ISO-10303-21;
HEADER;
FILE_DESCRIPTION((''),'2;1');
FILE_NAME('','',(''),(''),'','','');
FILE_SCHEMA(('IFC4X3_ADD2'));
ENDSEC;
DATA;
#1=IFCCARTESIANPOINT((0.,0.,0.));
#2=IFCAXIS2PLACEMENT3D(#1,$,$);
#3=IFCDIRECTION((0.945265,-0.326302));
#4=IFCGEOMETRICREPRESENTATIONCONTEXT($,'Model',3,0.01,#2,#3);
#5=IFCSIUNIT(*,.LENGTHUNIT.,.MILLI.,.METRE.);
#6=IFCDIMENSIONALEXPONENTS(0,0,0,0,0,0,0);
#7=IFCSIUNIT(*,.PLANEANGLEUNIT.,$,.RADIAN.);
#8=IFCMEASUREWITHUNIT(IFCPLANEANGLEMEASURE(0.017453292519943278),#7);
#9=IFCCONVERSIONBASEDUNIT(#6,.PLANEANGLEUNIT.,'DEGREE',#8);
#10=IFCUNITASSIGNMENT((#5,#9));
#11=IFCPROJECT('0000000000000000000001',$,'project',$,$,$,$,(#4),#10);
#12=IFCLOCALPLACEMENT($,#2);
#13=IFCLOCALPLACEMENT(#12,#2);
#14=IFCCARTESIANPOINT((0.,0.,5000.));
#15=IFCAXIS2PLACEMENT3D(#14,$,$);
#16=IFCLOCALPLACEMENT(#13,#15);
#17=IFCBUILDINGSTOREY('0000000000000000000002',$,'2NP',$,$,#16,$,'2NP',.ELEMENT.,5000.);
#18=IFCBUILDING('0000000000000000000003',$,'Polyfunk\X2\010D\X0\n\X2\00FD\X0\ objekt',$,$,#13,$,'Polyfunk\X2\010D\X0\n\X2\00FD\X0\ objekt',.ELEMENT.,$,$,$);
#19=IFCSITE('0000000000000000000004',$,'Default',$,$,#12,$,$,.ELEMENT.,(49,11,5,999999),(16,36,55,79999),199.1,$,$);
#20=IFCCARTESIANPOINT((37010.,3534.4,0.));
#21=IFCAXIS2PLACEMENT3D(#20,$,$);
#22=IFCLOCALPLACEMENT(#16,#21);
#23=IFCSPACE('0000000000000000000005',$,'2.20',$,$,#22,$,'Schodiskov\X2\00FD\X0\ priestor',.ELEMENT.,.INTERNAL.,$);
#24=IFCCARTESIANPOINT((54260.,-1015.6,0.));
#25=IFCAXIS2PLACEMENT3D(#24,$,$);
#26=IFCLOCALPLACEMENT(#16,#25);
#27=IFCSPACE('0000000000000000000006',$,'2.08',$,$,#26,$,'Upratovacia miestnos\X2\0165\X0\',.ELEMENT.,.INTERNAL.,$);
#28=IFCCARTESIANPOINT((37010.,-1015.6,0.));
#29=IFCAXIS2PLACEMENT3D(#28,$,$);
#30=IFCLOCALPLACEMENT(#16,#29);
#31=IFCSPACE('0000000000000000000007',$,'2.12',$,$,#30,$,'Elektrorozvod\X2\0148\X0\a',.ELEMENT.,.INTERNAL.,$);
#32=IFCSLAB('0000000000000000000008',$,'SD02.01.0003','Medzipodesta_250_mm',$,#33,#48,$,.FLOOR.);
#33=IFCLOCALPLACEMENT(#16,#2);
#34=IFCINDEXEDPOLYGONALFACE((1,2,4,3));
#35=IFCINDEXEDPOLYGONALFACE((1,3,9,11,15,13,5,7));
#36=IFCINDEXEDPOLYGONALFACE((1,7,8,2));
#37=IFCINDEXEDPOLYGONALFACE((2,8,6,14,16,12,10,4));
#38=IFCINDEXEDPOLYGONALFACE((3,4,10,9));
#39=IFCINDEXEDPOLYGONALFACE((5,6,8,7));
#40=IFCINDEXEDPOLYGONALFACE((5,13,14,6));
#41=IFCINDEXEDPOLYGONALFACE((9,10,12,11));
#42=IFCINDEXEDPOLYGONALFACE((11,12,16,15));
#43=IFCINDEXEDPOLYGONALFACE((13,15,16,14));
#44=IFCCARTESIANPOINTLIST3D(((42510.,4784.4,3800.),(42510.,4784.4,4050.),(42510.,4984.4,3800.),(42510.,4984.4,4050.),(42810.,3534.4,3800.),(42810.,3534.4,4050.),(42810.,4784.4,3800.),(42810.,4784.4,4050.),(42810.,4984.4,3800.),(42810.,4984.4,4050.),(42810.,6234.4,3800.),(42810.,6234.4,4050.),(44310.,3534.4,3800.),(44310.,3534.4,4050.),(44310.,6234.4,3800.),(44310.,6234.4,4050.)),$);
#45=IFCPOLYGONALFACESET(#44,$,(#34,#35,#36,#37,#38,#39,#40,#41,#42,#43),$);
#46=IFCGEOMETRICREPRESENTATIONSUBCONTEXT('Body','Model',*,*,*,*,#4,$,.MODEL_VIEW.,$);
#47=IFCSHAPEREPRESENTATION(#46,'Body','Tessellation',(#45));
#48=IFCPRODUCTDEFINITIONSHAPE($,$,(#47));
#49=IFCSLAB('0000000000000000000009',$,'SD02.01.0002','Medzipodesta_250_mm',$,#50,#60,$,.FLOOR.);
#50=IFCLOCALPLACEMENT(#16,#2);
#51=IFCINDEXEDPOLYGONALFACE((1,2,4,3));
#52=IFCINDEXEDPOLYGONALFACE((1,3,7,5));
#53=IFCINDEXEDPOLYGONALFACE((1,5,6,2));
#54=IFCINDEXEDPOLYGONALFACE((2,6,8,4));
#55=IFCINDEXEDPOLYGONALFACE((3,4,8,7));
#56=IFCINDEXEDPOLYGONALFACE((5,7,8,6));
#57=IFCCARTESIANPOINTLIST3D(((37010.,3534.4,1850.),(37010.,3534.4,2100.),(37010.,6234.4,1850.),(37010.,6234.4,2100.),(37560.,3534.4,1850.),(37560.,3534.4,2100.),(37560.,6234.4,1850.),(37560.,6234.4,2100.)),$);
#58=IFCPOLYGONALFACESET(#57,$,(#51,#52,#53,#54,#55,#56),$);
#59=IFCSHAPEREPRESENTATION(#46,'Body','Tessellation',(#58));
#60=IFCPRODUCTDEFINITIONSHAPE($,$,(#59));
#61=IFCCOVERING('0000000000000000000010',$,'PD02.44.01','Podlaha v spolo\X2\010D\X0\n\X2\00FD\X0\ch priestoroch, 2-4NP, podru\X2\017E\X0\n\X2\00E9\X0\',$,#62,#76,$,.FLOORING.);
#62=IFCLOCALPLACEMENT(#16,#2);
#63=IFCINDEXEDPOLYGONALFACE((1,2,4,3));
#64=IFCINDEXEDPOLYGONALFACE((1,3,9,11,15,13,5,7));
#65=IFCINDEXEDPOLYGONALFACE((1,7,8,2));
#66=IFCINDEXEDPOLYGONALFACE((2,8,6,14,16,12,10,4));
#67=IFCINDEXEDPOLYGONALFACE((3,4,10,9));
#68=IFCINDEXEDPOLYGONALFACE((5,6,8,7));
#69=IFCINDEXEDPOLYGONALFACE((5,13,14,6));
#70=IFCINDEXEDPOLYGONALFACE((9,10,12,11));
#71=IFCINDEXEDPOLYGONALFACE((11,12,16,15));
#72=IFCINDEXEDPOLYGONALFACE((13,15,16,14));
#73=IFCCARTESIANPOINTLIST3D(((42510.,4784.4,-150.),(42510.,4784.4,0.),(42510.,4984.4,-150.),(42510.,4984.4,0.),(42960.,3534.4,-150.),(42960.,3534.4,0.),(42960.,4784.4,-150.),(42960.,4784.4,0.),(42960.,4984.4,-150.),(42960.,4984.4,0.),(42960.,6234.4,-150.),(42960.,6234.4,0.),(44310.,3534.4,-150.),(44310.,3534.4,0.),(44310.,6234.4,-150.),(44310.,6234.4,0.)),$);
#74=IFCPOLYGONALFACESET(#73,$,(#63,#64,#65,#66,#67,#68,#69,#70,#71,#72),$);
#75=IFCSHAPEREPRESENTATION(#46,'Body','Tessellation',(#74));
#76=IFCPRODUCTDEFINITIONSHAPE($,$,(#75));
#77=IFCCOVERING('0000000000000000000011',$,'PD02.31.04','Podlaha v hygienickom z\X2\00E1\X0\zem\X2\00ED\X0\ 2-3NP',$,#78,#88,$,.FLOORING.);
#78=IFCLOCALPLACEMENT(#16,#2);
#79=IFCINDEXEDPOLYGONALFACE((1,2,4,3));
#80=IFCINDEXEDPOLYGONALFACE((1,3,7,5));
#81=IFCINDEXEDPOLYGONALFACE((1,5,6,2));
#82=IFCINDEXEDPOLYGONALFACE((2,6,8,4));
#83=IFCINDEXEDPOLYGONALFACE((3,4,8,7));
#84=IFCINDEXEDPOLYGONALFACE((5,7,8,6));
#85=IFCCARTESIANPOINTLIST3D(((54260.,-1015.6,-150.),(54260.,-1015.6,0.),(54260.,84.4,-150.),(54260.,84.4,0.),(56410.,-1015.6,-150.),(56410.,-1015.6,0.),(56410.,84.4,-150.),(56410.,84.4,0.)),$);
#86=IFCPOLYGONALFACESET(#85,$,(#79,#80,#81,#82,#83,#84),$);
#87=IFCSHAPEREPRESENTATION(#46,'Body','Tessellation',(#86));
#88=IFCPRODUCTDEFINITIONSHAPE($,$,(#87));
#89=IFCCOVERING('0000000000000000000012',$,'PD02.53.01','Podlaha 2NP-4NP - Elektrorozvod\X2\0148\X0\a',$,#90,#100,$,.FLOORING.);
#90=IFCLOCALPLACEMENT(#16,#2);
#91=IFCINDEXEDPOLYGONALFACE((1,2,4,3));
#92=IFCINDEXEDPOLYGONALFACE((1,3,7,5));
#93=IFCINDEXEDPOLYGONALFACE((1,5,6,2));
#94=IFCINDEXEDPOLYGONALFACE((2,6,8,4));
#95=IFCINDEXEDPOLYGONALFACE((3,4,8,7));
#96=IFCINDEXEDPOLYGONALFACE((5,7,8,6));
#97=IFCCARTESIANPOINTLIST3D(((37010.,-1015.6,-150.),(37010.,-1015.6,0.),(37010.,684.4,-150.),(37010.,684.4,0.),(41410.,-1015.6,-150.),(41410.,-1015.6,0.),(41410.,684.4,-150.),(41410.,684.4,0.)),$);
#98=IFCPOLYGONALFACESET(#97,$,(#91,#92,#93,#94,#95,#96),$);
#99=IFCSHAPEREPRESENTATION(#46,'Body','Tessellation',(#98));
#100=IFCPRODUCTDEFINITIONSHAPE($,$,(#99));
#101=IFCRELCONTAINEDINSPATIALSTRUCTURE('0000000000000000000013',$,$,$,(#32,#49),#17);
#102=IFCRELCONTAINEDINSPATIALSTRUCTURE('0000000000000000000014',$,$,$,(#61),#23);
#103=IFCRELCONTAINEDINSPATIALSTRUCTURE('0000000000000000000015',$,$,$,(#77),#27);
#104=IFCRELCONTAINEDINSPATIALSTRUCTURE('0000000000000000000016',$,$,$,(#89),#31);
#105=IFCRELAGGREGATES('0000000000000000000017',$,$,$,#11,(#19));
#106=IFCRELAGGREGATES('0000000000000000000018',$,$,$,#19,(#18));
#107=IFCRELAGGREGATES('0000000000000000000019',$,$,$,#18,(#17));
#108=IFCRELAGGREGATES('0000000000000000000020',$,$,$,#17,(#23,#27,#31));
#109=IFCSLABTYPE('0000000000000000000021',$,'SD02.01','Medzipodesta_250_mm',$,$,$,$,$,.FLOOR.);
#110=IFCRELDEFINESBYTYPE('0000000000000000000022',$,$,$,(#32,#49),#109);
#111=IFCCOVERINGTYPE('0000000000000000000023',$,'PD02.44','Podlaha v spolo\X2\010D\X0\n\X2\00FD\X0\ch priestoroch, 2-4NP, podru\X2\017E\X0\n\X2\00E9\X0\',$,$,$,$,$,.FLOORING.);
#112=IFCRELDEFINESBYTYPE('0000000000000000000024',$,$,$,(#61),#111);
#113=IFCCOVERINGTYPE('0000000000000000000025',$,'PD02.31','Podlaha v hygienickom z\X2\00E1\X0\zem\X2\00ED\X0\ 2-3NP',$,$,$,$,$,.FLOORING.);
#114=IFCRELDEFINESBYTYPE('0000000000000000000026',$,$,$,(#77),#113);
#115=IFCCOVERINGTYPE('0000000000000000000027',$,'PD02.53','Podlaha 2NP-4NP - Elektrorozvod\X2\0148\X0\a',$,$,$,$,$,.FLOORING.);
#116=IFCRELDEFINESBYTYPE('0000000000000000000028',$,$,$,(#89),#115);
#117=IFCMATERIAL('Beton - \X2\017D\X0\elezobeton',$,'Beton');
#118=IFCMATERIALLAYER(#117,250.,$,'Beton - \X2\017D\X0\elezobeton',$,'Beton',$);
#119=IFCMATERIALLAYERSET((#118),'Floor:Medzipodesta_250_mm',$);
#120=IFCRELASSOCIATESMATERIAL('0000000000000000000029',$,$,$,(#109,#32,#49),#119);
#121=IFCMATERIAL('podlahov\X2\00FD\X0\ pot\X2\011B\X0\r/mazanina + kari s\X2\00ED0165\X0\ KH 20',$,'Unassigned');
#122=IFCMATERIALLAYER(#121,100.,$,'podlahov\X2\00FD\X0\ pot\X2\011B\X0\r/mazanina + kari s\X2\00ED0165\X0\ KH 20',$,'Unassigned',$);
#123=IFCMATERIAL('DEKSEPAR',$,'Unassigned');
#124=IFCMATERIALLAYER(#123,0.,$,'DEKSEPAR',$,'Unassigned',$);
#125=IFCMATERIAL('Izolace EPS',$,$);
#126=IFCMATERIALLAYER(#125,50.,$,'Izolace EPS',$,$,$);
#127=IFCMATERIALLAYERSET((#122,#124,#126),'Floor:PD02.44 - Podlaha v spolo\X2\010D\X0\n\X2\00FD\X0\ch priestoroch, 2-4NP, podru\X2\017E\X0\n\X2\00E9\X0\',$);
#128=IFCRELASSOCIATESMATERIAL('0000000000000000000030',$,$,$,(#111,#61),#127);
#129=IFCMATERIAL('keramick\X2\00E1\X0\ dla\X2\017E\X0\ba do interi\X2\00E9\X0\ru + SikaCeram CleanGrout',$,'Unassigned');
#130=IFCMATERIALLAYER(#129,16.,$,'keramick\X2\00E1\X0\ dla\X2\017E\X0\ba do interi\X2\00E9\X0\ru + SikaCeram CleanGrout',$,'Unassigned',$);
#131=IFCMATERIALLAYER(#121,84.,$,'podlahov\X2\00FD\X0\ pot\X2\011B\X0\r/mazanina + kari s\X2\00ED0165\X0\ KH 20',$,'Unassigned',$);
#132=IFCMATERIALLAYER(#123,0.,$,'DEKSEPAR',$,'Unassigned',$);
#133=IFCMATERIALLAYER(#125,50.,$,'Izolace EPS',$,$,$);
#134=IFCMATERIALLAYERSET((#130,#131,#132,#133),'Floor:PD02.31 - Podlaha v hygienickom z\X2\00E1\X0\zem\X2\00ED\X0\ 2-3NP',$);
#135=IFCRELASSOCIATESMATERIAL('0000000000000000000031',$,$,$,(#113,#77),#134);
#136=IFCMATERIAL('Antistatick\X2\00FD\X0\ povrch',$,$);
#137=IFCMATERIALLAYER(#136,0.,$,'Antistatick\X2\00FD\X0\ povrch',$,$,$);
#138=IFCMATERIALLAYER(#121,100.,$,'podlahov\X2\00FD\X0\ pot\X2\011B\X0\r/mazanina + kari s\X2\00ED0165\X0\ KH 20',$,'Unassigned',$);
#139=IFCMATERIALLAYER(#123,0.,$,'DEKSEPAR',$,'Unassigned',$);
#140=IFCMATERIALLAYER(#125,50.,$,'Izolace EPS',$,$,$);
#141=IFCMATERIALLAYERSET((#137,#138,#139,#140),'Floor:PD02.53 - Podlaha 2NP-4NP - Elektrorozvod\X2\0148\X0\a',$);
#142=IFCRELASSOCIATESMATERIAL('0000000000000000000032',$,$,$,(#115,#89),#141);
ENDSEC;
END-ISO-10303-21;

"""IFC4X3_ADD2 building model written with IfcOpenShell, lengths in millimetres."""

from ifc_helpers import new_model, entity, si_unit, converted_unit, direction, frame, frame_2d, origin, place, context, subcontext, project, spatial, polyline, rectangle, outline, extrude, material, layer, layer_set, layer_usage, type_object, element, save


model = new_model("IFC4X3_ADD2")

# Units and contexts
model_context = context("Model", 3, precision=0.01, world=origin(), true_north=direction((0.945265, -0.326302)))
body_context = subcontext(model_context, "Body", "Model", "MODEL_VIEW")
ifc_project = project(units=[si_unit("LENGTHUNIT", "METRE", prefix="MILLI"), converted_unit("PLANEANGLEUNIT", "DEGREE", entity("IfcPlaneAngleMeasure", 0.017453292519943278), si_unit("PLANEANGLEUNIT", "RADIAN"), dimensions=[0, 0, 0, 0, 0, 0, 0])], contexts=[model_context])

# Site, building, storey
site_placement = place(None, origin())
site = spatial("IfcSite", under=ifc_project, at=site_placement, Name="Default", CompositionType="ELEMENT", RefLatitude=(49, 11, 5, 999999), RefLongitude=(16, 36, 55, 79999), RefElevation=199.1)
building_placement = place(site_placement, origin())
building = spatial("IfcBuilding", under=site, at=building_placement, Name="Polyfunkčný objekt", LongName="Polyfunkčný objekt", CompositionType="ELEMENT")
storey_placement = place(building_placement, frame((0.0, 0.0, 5000.0)))
storey = spatial("IfcBuildingStorey", under=building, at=storey_placement, Name="2NP", LongName="2NP", CompositionType="ELEMENT", Elevation=5000.0)

# Shared definitions
ifc_material_1 = material(Name="Beton - Železobeton", Category="Beton")

# Slabs
ifc_layer_1 = layer(ifc_material_1, 250.0, Name="Beton - Železobeton", Category="Beton")
ifc_layer_set_1 = layer_set([ifc_layer_1], Name="Floor:Medzipodesta_250_mm")
ifc_layer_usage_1 = layer_usage(ifc_layer_set_1, "AXIS3", "POSITIVE", 0.0)
slab_type_1 = type_object("IfcSlabType", Name="SD02.01", Description="Medzipodesta_250_mm", PredefinedType="FLOOR", material=ifc_layer_set_1)
slab_1_placement = place(storey_placement, origin())
element("IfcSlab", 1, at=slab_1_placement, inside=storey, type_object=slab_type_1, material=ifc_layer_usage_1, Name="SD02.01.0003", Description="Medzipodesta_250_mm", PredefinedType="FLOOR", context=body_context, shape_type="SweptSolid", body=[
    extrude(outline(polyline([(-100.0, -600.0), (100.0, -600.0), (100.0, -300.0), (1350.0, -300.0), (1350.0, 1200.0), (-1350.0, 1200.0), (-1350.0, -300.0), (-100.0, -300.0), (-100.0, -600.0)])), frame((43110.0, 4884.4, 4050.0), z_axis=(0.0, 0.0, -1.0), x_axis=(0.0, 1.0, 0.0)), (0.0, 0.0, 1.0), 250.0),
])
ifc_layer_usage_2 = layer_usage(ifc_layer_set_1, "AXIS3", "POSITIVE", 0.0)
slab_2_placement = place(storey_placement, origin())
element("IfcSlab", 2, at=slab_2_placement, inside=storey, type_object=slab_type_1, material=ifc_layer_usage_2, Name="SD02.01.0002", Description="Medzipodesta_250_mm", PredefinedType="FLOOR", context=body_context, shape_type="SweptSolid", body=[
    extrude(rectangle(XDim=2700.0, YDim=550.0, at=frame_2d((0.0, 0.0), x_axis=(1.0, 0.0))), frame((37285.0, 4884.4, 2100.0), z_axis=(0.0, 0.0, -1.0), x_axis=(0.0, 1.0, 0.0)), (0.0, 0.0, 1.0), 250.0),
])

# Shared definitions
space_1_placement = place(storey_placement, frame((37010.0, 3534.4, 0.0)))
space_1 = spatial("IfcSpace", under=storey, at=space_1_placement, Name="2.20", LongName="Schodiskový priestor", CompositionType="ELEMENT", PredefinedType="INTERNAL")

# Covering
ifc_material_2 = material(Name="podlahový potěr/mazanina + kari síť KH 20", Category="Unassigned")
ifc_layer_2 = layer(ifc_material_2, 100.0, Name="podlahový potěr/mazanina + kari síť KH 20", Category="Unassigned")
ifc_material_3 = material(Name="DEKSEPAR", Category="Unassigned")
ifc_layer_3 = layer(ifc_material_3, 0.0, Name="DEKSEPAR", Category="Unassigned")
ifc_material_4 = material(Name="Izolace EPS")
ifc_layer_4 = layer(ifc_material_4, 50.0, Name="Izolace EPS")
ifc_layer_set_2 = layer_set([ifc_layer_2, ifc_layer_3, ifc_layer_4], Name="Floor:PD02.44 - Podlaha v spoločných priestoroch, 2-4NP, podružné")
ifc_layer_usage_3 = layer_usage(ifc_layer_set_2, "AXIS3", "POSITIVE", 0.0)
covering_type_1 = type_object("IfcCoveringType", Name="PD02.44", Description="Podlaha v spoločných priestoroch, 2-4NP, podružné", PredefinedType="FLOORING", material=ifc_layer_set_2)
covering_1_placement = place(storey_placement, origin())
element("IfcCovering", 3, at=covering_1_placement, inside=space_1, type_object=covering_type_1, material=ifc_layer_usage_3, Name="PD02.44.01", Description="Podlaha v spoločných priestoroch, 2-4NP, podružné", PredefinedType="FLOORING", context=body_context, shape_type="SweptSolid", body=[
    extrude(outline(polyline([(-100.0, -675.0), (100.0, -675.0), (100.0, -225.0), (1350.0, -225.0), (1350.0, 1125.0), (-1350.0, 1125.0), (-1350.0, -225.0), (-100.0, -225.0), (-100.0, -675.0)])), frame((43185.0, 4884.4, 0.0), z_axis=(0.0, 0.0, -1.0), x_axis=(0.0, 1.0, 0.0)), (0.0, 0.0, 1.0), 150.0),
])

# Shared definitions
ifc_material_5 = material(Name="keramická dlažba do interiéru + SikaCeram CleanGrout", Category="Unassigned")
ifc_layer_5 = layer(ifc_material_5, 16.0, Name="keramická dlažba do interiéru + SikaCeram CleanGrout", Category="Unassigned")
ifc_layer_6 = layer(ifc_material_2, 84.0, Name="podlahový potěr/mazanina + kari síť KH 20", Category="Unassigned")
ifc_layer_7 = layer(ifc_material_3, 0.0, Name="DEKSEPAR", Category="Unassigned")
ifc_layer_8 = layer(ifc_material_4, 50.0, Name="Izolace EPS")
ifc_layer_set_3 = layer_set([ifc_layer_5, ifc_layer_6, ifc_layer_7, ifc_layer_8], Name="Floor:PD02.31 - Podlaha v hygienickom zázemí 2-3NP")
covering_type_2 = type_object("IfcCoveringType", Name="PD02.31", Description="Podlaha v hygienickom zázemí 2-3NP", PredefinedType="FLOORING", material=ifc_layer_set_3)

# Shared definitions
space_2_placement = place(storey_placement, frame((54260.0, -1015.6, 0.0)))
space_2 = spatial("IfcSpace", under=storey, at=space_2_placement, Name="2.08", LongName="Upratovacia miestnosť", CompositionType="ELEMENT", PredefinedType="INTERNAL")

# Covering
ifc_layer_usage_4 = layer_usage(ifc_layer_set_3, "AXIS3", "POSITIVE", 0.0)
covering_2_placement = place(storey_placement, origin())
element("IfcCovering", 4, at=covering_2_placement, inside=space_2, type_object=covering_type_2, material=ifc_layer_usage_4, Name="PD02.31.04", Description="Podlaha v hygienickom zázemí 2-3NP", PredefinedType="FLOORING", context=body_context, shape_type="SweptSolid", body=[
    extrude(rectangle(XDim=1100.0, YDim=2150.0, at=frame_2d((0.0, 0.0), x_axis=(1.0, 0.0))), frame((55335.0, -465.6, 0.0), z_axis=(0.0, 0.0, -1.0), x_axis=(0.0, 1.0, 0.0)), (0.0, 0.0, 1.0), 150.0),
])

# Shared definitions
space_3_placement = place(storey_placement, frame((37010.0, -1015.6, 0.0)))
space_3 = spatial("IfcSpace", under=storey, at=space_3_placement, Name="2.12", LongName="Elektrorozvodňa", CompositionType="ELEMENT", PredefinedType="INTERNAL")

# Covering
ifc_material_6 = material(Name="Antistatický povrch")
ifc_layer_9 = layer(ifc_material_6, 0.0, Name="Antistatický povrch")
ifc_layer_10 = layer(ifc_material_2, 100.0, Name="podlahový potěr/mazanina + kari síť KH 20", Category="Unassigned")
ifc_layer_11 = layer(ifc_material_3, 0.0, Name="DEKSEPAR", Category="Unassigned")
ifc_layer_12 = layer(ifc_material_4, 50.0, Name="Izolace EPS")
ifc_layer_set_4 = layer_set([ifc_layer_9, ifc_layer_10, ifc_layer_11, ifc_layer_12], Name="Floor:PD02.53 - Podlaha 2NP-4NP - Elektrorozvodňa")
ifc_layer_usage_5 = layer_usage(ifc_layer_set_4, "AXIS3", "POSITIVE", 0.0)
covering_type_3 = type_object("IfcCoveringType", Name="PD02.53", Description="Podlaha 2NP-4NP - Elektrorozvodňa", PredefinedType="FLOORING", material=ifc_layer_set_4)
covering_3_placement = place(storey_placement, origin())
element("IfcCovering", 5, at=covering_3_placement, inside=space_3, type_object=covering_type_3, material=ifc_layer_usage_5, Name="PD02.53.01", Description="Podlaha 2NP-4NP - Elektrorozvodňa", PredefinedType="FLOORING", context=body_context, shape_type="SweptSolid", body=[
    extrude(rectangle(XDim=1700.0, YDim=4400.0, at=frame_2d((0.0, 0.0), x_axis=(1.0, 0.0))), frame((39210.0, -165.6, 0.0), z_axis=(0.0, 0.0, -1.0), x_axis=(0.0, 1.0, 0.0)), (0.0, 0.0, 1.0), 150.0),
])

save(model, "model.ifc")
